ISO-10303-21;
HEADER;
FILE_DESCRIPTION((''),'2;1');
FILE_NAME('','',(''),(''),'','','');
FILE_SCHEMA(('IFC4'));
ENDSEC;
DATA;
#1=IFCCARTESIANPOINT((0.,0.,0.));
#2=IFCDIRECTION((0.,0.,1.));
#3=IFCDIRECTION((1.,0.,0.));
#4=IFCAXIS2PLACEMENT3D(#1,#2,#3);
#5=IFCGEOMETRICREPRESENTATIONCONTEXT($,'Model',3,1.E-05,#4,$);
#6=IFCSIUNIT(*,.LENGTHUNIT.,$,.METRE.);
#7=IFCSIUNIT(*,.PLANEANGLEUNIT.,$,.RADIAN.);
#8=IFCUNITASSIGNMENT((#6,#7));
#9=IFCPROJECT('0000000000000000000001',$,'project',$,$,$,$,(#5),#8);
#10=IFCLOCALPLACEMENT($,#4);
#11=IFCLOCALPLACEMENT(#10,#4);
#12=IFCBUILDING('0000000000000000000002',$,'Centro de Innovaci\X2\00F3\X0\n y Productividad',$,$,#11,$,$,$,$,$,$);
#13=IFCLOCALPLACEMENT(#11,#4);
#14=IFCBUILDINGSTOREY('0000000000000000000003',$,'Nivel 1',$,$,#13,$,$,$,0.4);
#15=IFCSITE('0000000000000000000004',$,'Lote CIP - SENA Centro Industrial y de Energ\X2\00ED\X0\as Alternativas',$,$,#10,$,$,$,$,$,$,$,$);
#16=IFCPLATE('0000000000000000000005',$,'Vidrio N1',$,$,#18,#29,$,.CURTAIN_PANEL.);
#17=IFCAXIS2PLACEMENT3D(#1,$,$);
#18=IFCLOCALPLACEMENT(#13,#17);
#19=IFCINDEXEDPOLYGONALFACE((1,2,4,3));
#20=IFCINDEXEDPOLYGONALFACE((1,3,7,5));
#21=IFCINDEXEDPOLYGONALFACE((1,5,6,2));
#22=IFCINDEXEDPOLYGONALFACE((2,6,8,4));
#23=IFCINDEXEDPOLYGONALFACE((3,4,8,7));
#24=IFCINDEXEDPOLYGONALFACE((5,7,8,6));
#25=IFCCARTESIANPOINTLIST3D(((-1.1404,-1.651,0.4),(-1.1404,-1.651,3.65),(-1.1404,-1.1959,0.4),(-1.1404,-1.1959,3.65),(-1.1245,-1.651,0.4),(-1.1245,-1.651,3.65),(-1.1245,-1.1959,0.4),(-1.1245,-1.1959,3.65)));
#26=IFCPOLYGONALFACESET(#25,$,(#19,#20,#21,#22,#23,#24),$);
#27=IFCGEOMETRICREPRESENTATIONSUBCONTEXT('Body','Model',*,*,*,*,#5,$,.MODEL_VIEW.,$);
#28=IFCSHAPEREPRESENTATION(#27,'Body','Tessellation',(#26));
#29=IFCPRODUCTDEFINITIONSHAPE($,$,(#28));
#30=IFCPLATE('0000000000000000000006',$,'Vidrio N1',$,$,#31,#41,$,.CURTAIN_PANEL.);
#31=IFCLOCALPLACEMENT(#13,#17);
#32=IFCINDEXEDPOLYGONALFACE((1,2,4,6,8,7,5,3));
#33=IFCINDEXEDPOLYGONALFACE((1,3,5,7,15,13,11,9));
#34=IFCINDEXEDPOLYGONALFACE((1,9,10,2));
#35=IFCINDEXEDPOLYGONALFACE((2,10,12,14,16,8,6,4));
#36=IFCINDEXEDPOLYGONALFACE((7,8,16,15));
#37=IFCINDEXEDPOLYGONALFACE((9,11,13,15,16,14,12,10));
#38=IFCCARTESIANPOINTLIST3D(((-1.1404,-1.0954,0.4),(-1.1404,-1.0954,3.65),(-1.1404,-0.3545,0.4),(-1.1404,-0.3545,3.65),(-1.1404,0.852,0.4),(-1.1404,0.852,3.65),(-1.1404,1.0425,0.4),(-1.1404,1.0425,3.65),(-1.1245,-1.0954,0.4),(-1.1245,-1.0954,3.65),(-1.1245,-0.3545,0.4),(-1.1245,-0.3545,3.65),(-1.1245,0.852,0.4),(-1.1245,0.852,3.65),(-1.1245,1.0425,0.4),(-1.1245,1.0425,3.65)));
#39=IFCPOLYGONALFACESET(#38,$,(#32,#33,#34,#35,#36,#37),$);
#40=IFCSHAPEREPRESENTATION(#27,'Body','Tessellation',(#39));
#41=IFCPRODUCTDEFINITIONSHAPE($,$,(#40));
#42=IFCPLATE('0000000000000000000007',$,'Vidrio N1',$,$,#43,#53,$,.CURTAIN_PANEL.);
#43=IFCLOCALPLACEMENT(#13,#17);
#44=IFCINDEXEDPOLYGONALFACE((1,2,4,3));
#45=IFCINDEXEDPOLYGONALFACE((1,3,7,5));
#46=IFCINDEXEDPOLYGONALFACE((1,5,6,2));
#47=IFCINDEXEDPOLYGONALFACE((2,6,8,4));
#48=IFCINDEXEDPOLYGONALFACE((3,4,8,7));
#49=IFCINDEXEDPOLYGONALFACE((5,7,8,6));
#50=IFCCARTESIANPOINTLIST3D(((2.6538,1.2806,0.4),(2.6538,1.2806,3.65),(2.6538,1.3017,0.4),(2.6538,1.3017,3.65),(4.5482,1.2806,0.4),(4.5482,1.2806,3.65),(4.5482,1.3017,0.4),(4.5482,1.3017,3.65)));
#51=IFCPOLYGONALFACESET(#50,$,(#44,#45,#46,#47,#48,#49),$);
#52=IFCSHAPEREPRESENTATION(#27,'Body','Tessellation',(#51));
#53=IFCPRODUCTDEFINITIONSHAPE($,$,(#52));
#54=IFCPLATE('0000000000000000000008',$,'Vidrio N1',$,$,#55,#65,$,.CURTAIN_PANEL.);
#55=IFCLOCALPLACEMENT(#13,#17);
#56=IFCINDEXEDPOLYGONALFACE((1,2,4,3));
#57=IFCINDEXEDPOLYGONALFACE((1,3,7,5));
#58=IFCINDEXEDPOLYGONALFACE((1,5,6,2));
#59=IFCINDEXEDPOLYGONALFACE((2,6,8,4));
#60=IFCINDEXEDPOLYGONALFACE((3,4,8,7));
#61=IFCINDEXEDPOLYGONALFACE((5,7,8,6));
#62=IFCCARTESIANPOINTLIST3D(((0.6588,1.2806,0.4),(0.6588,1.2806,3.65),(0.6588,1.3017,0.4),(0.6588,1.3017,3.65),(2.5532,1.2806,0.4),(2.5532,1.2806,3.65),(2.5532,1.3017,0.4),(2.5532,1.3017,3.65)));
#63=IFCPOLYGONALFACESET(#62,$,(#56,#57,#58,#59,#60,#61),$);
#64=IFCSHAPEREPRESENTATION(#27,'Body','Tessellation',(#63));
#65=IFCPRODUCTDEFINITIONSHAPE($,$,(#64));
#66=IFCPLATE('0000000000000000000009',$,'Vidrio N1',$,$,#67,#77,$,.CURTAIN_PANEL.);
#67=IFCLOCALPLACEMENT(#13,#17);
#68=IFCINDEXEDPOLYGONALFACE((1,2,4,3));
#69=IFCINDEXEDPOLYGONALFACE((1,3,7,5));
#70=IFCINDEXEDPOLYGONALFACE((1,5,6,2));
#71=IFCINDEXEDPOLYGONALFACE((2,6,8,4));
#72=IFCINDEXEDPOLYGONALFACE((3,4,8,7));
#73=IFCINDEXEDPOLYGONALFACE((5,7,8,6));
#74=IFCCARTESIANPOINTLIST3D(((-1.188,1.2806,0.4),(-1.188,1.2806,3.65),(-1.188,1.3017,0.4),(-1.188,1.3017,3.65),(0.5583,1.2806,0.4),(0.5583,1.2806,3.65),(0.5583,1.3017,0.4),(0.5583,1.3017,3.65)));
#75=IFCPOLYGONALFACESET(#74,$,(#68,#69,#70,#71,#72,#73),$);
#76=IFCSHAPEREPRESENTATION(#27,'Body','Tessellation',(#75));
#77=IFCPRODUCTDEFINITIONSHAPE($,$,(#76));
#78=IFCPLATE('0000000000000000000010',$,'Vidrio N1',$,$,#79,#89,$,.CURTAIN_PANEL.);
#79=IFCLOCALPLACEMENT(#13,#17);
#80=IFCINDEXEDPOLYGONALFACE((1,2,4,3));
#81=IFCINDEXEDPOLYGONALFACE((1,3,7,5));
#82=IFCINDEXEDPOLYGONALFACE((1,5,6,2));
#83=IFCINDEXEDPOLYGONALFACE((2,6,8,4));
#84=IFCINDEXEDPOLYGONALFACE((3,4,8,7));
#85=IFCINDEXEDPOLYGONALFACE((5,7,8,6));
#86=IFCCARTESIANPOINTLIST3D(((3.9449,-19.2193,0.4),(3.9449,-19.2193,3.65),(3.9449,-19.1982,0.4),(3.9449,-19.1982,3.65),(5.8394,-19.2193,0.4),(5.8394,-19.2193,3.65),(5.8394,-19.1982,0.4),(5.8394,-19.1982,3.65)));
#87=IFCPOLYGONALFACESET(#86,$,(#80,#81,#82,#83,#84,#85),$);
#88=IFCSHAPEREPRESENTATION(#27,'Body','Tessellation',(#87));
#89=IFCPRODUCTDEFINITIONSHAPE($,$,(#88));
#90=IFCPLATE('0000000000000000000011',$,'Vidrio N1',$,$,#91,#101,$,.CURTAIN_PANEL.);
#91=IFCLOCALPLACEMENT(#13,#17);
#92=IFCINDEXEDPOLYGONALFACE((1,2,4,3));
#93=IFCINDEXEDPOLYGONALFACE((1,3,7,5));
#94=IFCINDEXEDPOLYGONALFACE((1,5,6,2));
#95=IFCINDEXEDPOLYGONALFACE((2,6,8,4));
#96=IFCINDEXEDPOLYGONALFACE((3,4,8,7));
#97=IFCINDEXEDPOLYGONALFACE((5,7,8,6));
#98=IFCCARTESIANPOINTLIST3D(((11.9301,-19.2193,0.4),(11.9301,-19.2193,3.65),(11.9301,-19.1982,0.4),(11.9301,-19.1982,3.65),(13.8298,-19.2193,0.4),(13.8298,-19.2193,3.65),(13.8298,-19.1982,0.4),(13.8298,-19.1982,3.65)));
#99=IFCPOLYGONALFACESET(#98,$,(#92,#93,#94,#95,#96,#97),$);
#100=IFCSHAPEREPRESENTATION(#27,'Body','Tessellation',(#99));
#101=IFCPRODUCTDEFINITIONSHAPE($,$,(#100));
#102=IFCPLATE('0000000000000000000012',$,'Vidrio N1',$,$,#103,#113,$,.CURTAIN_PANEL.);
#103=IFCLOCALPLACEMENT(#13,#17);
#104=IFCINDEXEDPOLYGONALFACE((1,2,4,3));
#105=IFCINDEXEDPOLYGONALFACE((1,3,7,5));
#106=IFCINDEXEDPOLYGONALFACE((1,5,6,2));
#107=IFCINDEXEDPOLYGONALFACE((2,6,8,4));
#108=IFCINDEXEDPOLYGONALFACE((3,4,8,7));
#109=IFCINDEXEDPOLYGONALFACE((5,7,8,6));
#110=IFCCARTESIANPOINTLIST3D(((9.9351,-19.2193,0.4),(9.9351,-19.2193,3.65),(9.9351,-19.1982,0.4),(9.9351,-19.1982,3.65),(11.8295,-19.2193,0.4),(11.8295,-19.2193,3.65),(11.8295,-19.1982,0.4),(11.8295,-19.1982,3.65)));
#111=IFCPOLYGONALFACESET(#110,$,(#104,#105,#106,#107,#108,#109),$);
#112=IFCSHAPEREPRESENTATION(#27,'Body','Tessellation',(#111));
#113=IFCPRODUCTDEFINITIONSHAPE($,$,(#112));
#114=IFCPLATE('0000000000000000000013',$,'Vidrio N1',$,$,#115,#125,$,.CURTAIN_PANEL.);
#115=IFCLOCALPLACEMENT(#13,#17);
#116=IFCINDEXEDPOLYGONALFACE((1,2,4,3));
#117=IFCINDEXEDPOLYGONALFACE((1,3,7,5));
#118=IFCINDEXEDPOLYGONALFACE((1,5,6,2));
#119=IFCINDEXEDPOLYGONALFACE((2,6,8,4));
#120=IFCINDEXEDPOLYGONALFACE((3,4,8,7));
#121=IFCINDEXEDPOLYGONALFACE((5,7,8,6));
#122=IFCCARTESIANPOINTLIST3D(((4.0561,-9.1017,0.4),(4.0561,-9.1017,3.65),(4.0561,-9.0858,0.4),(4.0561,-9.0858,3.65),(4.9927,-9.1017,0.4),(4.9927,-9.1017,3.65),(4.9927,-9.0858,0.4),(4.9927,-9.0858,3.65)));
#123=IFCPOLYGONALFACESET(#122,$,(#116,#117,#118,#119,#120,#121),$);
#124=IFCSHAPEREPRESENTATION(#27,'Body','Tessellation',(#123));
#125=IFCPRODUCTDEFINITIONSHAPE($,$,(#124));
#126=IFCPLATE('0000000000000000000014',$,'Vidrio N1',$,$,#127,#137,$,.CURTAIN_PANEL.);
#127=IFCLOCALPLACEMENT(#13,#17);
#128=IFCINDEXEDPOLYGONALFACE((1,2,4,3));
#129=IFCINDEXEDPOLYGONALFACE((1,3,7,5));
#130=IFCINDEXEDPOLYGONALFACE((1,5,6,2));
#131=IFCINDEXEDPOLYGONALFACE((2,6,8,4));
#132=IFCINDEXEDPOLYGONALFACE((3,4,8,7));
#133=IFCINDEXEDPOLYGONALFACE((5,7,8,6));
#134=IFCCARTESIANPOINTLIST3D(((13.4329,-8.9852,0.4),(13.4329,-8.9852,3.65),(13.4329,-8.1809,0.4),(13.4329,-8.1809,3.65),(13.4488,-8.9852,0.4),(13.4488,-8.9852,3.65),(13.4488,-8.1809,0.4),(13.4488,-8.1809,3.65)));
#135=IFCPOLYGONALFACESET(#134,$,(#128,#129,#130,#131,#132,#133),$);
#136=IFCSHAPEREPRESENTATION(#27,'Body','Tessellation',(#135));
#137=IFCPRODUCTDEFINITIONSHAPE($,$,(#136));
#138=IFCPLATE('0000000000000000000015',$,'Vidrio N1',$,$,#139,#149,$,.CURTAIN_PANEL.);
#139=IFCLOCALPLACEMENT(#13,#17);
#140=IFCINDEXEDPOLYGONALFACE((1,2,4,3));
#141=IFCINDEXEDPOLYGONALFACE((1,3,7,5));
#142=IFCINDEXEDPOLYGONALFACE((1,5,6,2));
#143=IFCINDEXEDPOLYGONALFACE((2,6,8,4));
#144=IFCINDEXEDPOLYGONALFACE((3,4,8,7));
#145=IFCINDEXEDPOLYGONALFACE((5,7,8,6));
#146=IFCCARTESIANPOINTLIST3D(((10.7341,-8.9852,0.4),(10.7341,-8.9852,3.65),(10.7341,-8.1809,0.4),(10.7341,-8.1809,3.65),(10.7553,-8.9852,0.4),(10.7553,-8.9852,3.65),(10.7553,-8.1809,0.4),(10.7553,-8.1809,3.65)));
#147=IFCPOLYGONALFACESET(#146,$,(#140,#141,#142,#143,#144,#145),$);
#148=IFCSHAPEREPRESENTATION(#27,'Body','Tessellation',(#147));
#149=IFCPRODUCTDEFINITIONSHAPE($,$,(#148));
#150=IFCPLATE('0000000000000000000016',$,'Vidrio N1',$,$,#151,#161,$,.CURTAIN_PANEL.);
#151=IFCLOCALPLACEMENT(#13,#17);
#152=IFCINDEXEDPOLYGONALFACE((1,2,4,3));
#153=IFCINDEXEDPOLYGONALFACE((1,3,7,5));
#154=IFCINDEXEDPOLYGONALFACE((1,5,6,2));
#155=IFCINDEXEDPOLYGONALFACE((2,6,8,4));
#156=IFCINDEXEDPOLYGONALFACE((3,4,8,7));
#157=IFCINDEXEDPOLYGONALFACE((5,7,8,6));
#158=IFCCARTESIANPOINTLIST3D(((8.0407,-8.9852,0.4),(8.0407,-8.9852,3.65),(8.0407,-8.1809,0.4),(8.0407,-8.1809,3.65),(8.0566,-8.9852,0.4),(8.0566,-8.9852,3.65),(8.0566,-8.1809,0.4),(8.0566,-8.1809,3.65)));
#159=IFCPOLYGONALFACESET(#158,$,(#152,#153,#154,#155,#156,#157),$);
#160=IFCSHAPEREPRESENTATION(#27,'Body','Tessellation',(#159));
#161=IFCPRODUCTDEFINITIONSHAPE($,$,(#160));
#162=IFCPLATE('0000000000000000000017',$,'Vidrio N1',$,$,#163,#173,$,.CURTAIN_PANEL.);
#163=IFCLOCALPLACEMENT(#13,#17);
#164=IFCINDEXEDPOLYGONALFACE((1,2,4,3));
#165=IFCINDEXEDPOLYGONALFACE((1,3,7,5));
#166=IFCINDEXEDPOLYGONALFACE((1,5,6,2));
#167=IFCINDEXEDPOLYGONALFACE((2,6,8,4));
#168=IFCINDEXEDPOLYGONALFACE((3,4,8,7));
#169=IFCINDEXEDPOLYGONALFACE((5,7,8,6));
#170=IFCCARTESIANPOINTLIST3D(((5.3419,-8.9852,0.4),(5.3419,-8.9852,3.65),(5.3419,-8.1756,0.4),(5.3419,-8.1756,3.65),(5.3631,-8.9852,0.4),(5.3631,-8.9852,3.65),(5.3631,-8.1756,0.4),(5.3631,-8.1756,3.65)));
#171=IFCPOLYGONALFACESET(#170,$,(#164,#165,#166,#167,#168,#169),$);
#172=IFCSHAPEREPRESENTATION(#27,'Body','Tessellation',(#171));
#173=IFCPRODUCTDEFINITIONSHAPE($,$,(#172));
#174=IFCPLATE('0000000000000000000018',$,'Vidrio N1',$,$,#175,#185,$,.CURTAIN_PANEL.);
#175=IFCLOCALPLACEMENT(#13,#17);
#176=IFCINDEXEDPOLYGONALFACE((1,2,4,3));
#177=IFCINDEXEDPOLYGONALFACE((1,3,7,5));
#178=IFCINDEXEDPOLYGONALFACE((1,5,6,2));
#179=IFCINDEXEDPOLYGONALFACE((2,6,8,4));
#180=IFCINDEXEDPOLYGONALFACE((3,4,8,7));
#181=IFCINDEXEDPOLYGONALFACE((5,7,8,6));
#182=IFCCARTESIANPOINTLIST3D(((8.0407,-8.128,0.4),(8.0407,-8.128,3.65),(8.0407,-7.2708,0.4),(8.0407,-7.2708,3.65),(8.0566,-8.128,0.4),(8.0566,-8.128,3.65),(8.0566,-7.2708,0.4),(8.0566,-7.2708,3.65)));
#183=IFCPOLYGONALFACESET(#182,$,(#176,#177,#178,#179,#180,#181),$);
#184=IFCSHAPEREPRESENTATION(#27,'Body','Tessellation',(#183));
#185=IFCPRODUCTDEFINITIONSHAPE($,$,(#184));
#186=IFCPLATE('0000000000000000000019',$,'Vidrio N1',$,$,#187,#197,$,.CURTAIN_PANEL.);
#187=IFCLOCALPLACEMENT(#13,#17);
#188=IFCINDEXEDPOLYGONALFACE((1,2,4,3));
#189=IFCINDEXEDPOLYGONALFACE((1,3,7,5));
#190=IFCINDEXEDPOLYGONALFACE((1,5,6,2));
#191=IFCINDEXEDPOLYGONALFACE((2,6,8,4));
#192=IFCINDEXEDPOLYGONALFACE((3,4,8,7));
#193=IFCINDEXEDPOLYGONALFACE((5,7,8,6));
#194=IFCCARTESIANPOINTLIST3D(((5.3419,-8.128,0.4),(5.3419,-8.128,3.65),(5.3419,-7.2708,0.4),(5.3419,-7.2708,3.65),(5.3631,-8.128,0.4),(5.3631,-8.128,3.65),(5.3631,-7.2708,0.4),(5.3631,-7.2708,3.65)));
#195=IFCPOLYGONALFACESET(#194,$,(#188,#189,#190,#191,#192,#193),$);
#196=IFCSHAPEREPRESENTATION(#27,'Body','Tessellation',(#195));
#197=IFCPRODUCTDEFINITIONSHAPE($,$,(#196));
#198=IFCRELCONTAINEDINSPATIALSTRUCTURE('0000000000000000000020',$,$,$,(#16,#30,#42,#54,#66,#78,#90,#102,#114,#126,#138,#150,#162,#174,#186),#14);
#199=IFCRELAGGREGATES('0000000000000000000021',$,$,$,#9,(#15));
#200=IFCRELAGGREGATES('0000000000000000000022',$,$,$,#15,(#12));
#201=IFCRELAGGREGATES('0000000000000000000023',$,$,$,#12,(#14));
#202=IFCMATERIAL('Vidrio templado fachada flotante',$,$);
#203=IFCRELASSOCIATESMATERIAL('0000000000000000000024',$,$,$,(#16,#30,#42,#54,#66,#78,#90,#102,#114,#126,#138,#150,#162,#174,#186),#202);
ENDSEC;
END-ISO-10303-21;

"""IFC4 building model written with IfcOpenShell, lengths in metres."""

from ifc_helpers import new_model, si_unit, frame, origin_with_axes, place, context, subcontext, project, spatial, polyline, outline, extrude, material, element, save


model = new_model("IFC4")

# Units and contexts
model_context = context("Model", 3, precision=1e-05, world=origin_with_axes())
body_context = subcontext(model_context, "Body", "Model", "MODEL_VIEW")
ifc_project = project(units=[si_unit("LENGTHUNIT", "METRE"), si_unit("PLANEANGLEUNIT", "RADIAN")], contexts=[model_context])

# Site, building, storey
site_placement = place(None, origin_with_axes())
site = spatial("IfcSite", under=ifc_project, at=site_placement, Name="Lote CIP - SENA Centro Industrial y de Energías Alternativas")
building_placement = place(site_placement, origin_with_axes())
building = spatial("IfcBuilding", under=site, at=building_placement, Name="Centro de Innovación y Productividad")
storey_placement = place(building_placement, origin_with_axes())
storey = spatial("IfcBuildingStorey", under=building, at=storey_placement, Name="Nivel 1", Elevation=0.4)

# Plates
ifc_material = material(Name="Vidrio templado fachada flotante")
plate_1_placement = place(storey_placement, origin_with_axes())
element("IfcPlate", 1, at=plate_1_placement, inside=storey, material=ifc_material, Name="Vidrio N1", PredefinedType="CURTAIN_PANEL", context=body_context, shape_type="SweptSolid", body=[
    extrude(outline(polyline([(-1.1245, -1.1959), (-1.1245, -1.651), (-1.1404, -1.651), (-1.1404, -1.1959), (-1.1245, -1.1959)])), frame((0.0, 0.0, 0.4)), (0.0, 0.0, 1.0), 3.25),
])
plate_2_placement = place(storey_placement, origin_with_axes())
element("IfcPlate", 2, at=plate_2_placement, inside=storey, material=ifc_material, Name="Vidrio N1", PredefinedType="CURTAIN_PANEL", context=body_context, shape_type="SweptSolid", body=[
    extrude(outline(polyline([(-1.1245, 1.0425), (-1.1245, 0.852), (-1.1245, -0.3545), (-1.1245, -1.0954), (-1.1404, -1.0954), (-1.1404, -0.3545), (-1.1404, 0.852), (-1.1404, 1.0425), (-1.1245, 1.0425)])), frame((0.0, 0.0, 0.4)), (0.0, 0.0, 1.0), 3.25),
])
plate_3_placement = place(storey_placement, origin_with_axes())
element("IfcPlate", 3, at=plate_3_placement, inside=storey, material=ifc_material, Name="Vidrio N1", PredefinedType="CURTAIN_PANEL", context=body_context, shape_type="SweptSolid", body=[
    extrude(outline(polyline([(2.6538, 1.2806), (2.6538, 1.3017), (4.5482, 1.3017), (4.5482, 1.2806), (2.6538, 1.2806)])), frame((0.0, 0.0, 0.4)), (0.0, 0.0, 1.0), 3.25),
])
plate_4_placement = place(storey_placement, origin_with_axes())
element("IfcPlate", 4, at=plate_4_placement, inside=storey, material=ifc_material, Name="Vidrio N1", PredefinedType="CURTAIN_PANEL", context=body_context, shape_type="SweptSolid", body=[
    extrude(outline(polyline([(2.5532, 1.3017), (2.5532, 1.2806), (0.6588, 1.2806), (0.6588, 1.3017), (2.5532, 1.3017)])), frame((0.0, 0.0, 0.4)), (0.0, 0.0, 1.0), 3.25),
])
plate_5_placement = place(storey_placement, origin_with_axes())
element("IfcPlate", 5, at=plate_5_placement, inside=storey, material=ifc_material, Name="Vidrio N1", PredefinedType="CURTAIN_PANEL", context=body_context, shape_type="SweptSolid", body=[
    extrude(outline(polyline([(0.5583, 1.2806), (-1.188, 1.2806), (-1.188, 1.3017), (0.5583, 1.3017), (0.5583, 1.2806)])), frame((0.0, 0.0, 0.4)), (0.0, 0.0, 1.0), 3.25),
])
plate_6_placement = place(storey_placement, origin_with_axes())
element("IfcPlate", 6, at=plate_6_placement, inside=storey, material=ifc_material, Name="Vidrio N1", PredefinedType="CURTAIN_PANEL", context=body_context, shape_type="SweptSolid", body=[
    extrude(outline(polyline([(3.9449, -19.2193), (3.9449, -19.1982), (5.8394, -19.1982), (5.8394, -19.2193), (3.9449, -19.2193)])), frame((0.0, 0.0, 0.4)), (0.0, 0.0, 1.0), 3.25),
])
plate_7_placement = place(storey_placement, origin_with_axes())
element("IfcPlate", 7, at=plate_7_placement, inside=storey, material=ifc_material, Name="Vidrio N1", PredefinedType="CURTAIN_PANEL", context=body_context, shape_type="SweptSolid", body=[
    extrude(outline(polyline([(13.8298, -19.2193), (11.9301, -19.2193), (11.9301, -19.1982), (13.8298, -19.1982), (13.8298, -19.2193)])), frame((0.0, 0.0, 0.4)), (0.0, 0.0, 1.0), 3.25),
])
plate_8_placement = place(storey_placement, origin_with_axes())
element("IfcPlate", 8, at=plate_8_placement, inside=storey, material=ifc_material, Name="Vidrio N1", PredefinedType="CURTAIN_PANEL", context=body_context, shape_type="SweptSolid", body=[
    extrude(outline(polyline([(11.8295, -19.1982), (11.8295, -19.2193), (9.9351, -19.2193), (9.9351, -19.1982), (11.8295, -19.1982)])), frame((0.0, 0.0, 0.4)), (0.0, 0.0, 1.0), 3.25),
])
plate_9_placement = place(storey_placement, origin_with_axes())
element("IfcPlate", 9, at=plate_9_placement, inside=storey, material=ifc_material, Name="Vidrio N1", PredefinedType="CURTAIN_PANEL", context=body_context, shape_type="SweptSolid", body=[
    extrude(outline(polyline([(4.9927, -9.0858), (4.9927, -9.1017), (4.0561, -9.1017), (4.0561, -9.0858), (4.9927, -9.0858)])), frame((0.0, 0.0, 0.4)), (0.0, 0.0, 1.0), 3.25),
])
plate_10_placement = place(storey_placement, origin_with_axes())
element("IfcPlate", 10, at=plate_10_placement, inside=storey, material=ifc_material, Name="Vidrio N1", PredefinedType="CURTAIN_PANEL", context=body_context, shape_type="SweptSolid", body=[
    extrude(outline(polyline([(13.4488, -8.9853), (13.4329, -8.9853), (13.4329, -8.1809), (13.4488, -8.1809), (13.4488, -8.9853)])), frame((0.0, 0.0, 0.4)), (0.0, 0.0, 1.0), 3.25),
])
plate_11_placement = place(storey_placement, origin_with_axes())
element("IfcPlate", 11, at=plate_11_placement, inside=storey, material=ifc_material, Name="Vidrio N1", PredefinedType="CURTAIN_PANEL", context=body_context, shape_type="SweptSolid", body=[
    extrude(outline(polyline([(10.7553, -8.1809), (10.7553, -8.9853), (10.7341, -8.9853), (10.7341, -8.1809), (10.7553, -8.1809)])), frame((0.0, 0.0, 0.4)), (0.0, 0.0, 1.0), 3.25),
])
plate_12_placement = place(storey_placement, origin_with_axes())
element("IfcPlate", 12, at=plate_12_placement, inside=storey, material=ifc_material, Name="Vidrio N1", PredefinedType="CURTAIN_PANEL", context=body_context, shape_type="SweptSolid", body=[
    extrude(outline(polyline([(8.0566, -8.9853), (8.0407, -8.9853), (8.0407, -8.1809), (8.0566, -8.1809), (8.0566, -8.9853)])), frame((0.0, 0.0, 0.4)), (0.0, 0.0, 1.0), 3.25),
])
plate_13_placement = place(storey_placement, origin_with_axes())
element("IfcPlate", 13, at=plate_13_placement, inside=storey, material=ifc_material, Name="Vidrio N1", PredefinedType="CURTAIN_PANEL", context=body_context, shape_type="SweptSolid", body=[
    extrude(outline(polyline([(5.3631, -8.1756), (5.3631, -8.9853), (5.3419, -8.9853), (5.3419, -8.1756), (5.3631, -8.1756)])), frame((0.0, 0.0, 0.4)), (0.0, 0.0, 1.0), 3.25),
])
plate_14_placement = place(storey_placement, origin_with_axes())
element("IfcPlate", 14, at=plate_14_placement, inside=storey, material=ifc_material, Name="Vidrio N1", PredefinedType="CURTAIN_PANEL", context=body_context, shape_type="SweptSolid", body=[
    extrude(outline(polyline([(8.0407, -8.128), (8.0407, -7.2708), (8.0566, -7.2708), (8.0566, -8.128), (8.0407, -8.128)])), frame((0.0, 0.0, 0.4)), (0.0, 0.0, 1.0), 3.25),
])
plate_15_placement = place(storey_placement, origin_with_axes())
element("IfcPlate", 15, at=plate_15_placement, inside=storey, material=ifc_material, Name="Vidrio N1", PredefinedType="CURTAIN_PANEL", context=body_context, shape_type="SweptSolid", body=[
    extrude(outline(polyline([(5.3631, -7.2708), (5.3631, -8.128), (5.3419, -8.128), (5.3419, -7.2708), (5.3631, -7.2708)])), frame((0.0, 0.0, 0.4)), (0.0, 0.0, 1.0), 3.25),
])

save(model, "model.ifc")
